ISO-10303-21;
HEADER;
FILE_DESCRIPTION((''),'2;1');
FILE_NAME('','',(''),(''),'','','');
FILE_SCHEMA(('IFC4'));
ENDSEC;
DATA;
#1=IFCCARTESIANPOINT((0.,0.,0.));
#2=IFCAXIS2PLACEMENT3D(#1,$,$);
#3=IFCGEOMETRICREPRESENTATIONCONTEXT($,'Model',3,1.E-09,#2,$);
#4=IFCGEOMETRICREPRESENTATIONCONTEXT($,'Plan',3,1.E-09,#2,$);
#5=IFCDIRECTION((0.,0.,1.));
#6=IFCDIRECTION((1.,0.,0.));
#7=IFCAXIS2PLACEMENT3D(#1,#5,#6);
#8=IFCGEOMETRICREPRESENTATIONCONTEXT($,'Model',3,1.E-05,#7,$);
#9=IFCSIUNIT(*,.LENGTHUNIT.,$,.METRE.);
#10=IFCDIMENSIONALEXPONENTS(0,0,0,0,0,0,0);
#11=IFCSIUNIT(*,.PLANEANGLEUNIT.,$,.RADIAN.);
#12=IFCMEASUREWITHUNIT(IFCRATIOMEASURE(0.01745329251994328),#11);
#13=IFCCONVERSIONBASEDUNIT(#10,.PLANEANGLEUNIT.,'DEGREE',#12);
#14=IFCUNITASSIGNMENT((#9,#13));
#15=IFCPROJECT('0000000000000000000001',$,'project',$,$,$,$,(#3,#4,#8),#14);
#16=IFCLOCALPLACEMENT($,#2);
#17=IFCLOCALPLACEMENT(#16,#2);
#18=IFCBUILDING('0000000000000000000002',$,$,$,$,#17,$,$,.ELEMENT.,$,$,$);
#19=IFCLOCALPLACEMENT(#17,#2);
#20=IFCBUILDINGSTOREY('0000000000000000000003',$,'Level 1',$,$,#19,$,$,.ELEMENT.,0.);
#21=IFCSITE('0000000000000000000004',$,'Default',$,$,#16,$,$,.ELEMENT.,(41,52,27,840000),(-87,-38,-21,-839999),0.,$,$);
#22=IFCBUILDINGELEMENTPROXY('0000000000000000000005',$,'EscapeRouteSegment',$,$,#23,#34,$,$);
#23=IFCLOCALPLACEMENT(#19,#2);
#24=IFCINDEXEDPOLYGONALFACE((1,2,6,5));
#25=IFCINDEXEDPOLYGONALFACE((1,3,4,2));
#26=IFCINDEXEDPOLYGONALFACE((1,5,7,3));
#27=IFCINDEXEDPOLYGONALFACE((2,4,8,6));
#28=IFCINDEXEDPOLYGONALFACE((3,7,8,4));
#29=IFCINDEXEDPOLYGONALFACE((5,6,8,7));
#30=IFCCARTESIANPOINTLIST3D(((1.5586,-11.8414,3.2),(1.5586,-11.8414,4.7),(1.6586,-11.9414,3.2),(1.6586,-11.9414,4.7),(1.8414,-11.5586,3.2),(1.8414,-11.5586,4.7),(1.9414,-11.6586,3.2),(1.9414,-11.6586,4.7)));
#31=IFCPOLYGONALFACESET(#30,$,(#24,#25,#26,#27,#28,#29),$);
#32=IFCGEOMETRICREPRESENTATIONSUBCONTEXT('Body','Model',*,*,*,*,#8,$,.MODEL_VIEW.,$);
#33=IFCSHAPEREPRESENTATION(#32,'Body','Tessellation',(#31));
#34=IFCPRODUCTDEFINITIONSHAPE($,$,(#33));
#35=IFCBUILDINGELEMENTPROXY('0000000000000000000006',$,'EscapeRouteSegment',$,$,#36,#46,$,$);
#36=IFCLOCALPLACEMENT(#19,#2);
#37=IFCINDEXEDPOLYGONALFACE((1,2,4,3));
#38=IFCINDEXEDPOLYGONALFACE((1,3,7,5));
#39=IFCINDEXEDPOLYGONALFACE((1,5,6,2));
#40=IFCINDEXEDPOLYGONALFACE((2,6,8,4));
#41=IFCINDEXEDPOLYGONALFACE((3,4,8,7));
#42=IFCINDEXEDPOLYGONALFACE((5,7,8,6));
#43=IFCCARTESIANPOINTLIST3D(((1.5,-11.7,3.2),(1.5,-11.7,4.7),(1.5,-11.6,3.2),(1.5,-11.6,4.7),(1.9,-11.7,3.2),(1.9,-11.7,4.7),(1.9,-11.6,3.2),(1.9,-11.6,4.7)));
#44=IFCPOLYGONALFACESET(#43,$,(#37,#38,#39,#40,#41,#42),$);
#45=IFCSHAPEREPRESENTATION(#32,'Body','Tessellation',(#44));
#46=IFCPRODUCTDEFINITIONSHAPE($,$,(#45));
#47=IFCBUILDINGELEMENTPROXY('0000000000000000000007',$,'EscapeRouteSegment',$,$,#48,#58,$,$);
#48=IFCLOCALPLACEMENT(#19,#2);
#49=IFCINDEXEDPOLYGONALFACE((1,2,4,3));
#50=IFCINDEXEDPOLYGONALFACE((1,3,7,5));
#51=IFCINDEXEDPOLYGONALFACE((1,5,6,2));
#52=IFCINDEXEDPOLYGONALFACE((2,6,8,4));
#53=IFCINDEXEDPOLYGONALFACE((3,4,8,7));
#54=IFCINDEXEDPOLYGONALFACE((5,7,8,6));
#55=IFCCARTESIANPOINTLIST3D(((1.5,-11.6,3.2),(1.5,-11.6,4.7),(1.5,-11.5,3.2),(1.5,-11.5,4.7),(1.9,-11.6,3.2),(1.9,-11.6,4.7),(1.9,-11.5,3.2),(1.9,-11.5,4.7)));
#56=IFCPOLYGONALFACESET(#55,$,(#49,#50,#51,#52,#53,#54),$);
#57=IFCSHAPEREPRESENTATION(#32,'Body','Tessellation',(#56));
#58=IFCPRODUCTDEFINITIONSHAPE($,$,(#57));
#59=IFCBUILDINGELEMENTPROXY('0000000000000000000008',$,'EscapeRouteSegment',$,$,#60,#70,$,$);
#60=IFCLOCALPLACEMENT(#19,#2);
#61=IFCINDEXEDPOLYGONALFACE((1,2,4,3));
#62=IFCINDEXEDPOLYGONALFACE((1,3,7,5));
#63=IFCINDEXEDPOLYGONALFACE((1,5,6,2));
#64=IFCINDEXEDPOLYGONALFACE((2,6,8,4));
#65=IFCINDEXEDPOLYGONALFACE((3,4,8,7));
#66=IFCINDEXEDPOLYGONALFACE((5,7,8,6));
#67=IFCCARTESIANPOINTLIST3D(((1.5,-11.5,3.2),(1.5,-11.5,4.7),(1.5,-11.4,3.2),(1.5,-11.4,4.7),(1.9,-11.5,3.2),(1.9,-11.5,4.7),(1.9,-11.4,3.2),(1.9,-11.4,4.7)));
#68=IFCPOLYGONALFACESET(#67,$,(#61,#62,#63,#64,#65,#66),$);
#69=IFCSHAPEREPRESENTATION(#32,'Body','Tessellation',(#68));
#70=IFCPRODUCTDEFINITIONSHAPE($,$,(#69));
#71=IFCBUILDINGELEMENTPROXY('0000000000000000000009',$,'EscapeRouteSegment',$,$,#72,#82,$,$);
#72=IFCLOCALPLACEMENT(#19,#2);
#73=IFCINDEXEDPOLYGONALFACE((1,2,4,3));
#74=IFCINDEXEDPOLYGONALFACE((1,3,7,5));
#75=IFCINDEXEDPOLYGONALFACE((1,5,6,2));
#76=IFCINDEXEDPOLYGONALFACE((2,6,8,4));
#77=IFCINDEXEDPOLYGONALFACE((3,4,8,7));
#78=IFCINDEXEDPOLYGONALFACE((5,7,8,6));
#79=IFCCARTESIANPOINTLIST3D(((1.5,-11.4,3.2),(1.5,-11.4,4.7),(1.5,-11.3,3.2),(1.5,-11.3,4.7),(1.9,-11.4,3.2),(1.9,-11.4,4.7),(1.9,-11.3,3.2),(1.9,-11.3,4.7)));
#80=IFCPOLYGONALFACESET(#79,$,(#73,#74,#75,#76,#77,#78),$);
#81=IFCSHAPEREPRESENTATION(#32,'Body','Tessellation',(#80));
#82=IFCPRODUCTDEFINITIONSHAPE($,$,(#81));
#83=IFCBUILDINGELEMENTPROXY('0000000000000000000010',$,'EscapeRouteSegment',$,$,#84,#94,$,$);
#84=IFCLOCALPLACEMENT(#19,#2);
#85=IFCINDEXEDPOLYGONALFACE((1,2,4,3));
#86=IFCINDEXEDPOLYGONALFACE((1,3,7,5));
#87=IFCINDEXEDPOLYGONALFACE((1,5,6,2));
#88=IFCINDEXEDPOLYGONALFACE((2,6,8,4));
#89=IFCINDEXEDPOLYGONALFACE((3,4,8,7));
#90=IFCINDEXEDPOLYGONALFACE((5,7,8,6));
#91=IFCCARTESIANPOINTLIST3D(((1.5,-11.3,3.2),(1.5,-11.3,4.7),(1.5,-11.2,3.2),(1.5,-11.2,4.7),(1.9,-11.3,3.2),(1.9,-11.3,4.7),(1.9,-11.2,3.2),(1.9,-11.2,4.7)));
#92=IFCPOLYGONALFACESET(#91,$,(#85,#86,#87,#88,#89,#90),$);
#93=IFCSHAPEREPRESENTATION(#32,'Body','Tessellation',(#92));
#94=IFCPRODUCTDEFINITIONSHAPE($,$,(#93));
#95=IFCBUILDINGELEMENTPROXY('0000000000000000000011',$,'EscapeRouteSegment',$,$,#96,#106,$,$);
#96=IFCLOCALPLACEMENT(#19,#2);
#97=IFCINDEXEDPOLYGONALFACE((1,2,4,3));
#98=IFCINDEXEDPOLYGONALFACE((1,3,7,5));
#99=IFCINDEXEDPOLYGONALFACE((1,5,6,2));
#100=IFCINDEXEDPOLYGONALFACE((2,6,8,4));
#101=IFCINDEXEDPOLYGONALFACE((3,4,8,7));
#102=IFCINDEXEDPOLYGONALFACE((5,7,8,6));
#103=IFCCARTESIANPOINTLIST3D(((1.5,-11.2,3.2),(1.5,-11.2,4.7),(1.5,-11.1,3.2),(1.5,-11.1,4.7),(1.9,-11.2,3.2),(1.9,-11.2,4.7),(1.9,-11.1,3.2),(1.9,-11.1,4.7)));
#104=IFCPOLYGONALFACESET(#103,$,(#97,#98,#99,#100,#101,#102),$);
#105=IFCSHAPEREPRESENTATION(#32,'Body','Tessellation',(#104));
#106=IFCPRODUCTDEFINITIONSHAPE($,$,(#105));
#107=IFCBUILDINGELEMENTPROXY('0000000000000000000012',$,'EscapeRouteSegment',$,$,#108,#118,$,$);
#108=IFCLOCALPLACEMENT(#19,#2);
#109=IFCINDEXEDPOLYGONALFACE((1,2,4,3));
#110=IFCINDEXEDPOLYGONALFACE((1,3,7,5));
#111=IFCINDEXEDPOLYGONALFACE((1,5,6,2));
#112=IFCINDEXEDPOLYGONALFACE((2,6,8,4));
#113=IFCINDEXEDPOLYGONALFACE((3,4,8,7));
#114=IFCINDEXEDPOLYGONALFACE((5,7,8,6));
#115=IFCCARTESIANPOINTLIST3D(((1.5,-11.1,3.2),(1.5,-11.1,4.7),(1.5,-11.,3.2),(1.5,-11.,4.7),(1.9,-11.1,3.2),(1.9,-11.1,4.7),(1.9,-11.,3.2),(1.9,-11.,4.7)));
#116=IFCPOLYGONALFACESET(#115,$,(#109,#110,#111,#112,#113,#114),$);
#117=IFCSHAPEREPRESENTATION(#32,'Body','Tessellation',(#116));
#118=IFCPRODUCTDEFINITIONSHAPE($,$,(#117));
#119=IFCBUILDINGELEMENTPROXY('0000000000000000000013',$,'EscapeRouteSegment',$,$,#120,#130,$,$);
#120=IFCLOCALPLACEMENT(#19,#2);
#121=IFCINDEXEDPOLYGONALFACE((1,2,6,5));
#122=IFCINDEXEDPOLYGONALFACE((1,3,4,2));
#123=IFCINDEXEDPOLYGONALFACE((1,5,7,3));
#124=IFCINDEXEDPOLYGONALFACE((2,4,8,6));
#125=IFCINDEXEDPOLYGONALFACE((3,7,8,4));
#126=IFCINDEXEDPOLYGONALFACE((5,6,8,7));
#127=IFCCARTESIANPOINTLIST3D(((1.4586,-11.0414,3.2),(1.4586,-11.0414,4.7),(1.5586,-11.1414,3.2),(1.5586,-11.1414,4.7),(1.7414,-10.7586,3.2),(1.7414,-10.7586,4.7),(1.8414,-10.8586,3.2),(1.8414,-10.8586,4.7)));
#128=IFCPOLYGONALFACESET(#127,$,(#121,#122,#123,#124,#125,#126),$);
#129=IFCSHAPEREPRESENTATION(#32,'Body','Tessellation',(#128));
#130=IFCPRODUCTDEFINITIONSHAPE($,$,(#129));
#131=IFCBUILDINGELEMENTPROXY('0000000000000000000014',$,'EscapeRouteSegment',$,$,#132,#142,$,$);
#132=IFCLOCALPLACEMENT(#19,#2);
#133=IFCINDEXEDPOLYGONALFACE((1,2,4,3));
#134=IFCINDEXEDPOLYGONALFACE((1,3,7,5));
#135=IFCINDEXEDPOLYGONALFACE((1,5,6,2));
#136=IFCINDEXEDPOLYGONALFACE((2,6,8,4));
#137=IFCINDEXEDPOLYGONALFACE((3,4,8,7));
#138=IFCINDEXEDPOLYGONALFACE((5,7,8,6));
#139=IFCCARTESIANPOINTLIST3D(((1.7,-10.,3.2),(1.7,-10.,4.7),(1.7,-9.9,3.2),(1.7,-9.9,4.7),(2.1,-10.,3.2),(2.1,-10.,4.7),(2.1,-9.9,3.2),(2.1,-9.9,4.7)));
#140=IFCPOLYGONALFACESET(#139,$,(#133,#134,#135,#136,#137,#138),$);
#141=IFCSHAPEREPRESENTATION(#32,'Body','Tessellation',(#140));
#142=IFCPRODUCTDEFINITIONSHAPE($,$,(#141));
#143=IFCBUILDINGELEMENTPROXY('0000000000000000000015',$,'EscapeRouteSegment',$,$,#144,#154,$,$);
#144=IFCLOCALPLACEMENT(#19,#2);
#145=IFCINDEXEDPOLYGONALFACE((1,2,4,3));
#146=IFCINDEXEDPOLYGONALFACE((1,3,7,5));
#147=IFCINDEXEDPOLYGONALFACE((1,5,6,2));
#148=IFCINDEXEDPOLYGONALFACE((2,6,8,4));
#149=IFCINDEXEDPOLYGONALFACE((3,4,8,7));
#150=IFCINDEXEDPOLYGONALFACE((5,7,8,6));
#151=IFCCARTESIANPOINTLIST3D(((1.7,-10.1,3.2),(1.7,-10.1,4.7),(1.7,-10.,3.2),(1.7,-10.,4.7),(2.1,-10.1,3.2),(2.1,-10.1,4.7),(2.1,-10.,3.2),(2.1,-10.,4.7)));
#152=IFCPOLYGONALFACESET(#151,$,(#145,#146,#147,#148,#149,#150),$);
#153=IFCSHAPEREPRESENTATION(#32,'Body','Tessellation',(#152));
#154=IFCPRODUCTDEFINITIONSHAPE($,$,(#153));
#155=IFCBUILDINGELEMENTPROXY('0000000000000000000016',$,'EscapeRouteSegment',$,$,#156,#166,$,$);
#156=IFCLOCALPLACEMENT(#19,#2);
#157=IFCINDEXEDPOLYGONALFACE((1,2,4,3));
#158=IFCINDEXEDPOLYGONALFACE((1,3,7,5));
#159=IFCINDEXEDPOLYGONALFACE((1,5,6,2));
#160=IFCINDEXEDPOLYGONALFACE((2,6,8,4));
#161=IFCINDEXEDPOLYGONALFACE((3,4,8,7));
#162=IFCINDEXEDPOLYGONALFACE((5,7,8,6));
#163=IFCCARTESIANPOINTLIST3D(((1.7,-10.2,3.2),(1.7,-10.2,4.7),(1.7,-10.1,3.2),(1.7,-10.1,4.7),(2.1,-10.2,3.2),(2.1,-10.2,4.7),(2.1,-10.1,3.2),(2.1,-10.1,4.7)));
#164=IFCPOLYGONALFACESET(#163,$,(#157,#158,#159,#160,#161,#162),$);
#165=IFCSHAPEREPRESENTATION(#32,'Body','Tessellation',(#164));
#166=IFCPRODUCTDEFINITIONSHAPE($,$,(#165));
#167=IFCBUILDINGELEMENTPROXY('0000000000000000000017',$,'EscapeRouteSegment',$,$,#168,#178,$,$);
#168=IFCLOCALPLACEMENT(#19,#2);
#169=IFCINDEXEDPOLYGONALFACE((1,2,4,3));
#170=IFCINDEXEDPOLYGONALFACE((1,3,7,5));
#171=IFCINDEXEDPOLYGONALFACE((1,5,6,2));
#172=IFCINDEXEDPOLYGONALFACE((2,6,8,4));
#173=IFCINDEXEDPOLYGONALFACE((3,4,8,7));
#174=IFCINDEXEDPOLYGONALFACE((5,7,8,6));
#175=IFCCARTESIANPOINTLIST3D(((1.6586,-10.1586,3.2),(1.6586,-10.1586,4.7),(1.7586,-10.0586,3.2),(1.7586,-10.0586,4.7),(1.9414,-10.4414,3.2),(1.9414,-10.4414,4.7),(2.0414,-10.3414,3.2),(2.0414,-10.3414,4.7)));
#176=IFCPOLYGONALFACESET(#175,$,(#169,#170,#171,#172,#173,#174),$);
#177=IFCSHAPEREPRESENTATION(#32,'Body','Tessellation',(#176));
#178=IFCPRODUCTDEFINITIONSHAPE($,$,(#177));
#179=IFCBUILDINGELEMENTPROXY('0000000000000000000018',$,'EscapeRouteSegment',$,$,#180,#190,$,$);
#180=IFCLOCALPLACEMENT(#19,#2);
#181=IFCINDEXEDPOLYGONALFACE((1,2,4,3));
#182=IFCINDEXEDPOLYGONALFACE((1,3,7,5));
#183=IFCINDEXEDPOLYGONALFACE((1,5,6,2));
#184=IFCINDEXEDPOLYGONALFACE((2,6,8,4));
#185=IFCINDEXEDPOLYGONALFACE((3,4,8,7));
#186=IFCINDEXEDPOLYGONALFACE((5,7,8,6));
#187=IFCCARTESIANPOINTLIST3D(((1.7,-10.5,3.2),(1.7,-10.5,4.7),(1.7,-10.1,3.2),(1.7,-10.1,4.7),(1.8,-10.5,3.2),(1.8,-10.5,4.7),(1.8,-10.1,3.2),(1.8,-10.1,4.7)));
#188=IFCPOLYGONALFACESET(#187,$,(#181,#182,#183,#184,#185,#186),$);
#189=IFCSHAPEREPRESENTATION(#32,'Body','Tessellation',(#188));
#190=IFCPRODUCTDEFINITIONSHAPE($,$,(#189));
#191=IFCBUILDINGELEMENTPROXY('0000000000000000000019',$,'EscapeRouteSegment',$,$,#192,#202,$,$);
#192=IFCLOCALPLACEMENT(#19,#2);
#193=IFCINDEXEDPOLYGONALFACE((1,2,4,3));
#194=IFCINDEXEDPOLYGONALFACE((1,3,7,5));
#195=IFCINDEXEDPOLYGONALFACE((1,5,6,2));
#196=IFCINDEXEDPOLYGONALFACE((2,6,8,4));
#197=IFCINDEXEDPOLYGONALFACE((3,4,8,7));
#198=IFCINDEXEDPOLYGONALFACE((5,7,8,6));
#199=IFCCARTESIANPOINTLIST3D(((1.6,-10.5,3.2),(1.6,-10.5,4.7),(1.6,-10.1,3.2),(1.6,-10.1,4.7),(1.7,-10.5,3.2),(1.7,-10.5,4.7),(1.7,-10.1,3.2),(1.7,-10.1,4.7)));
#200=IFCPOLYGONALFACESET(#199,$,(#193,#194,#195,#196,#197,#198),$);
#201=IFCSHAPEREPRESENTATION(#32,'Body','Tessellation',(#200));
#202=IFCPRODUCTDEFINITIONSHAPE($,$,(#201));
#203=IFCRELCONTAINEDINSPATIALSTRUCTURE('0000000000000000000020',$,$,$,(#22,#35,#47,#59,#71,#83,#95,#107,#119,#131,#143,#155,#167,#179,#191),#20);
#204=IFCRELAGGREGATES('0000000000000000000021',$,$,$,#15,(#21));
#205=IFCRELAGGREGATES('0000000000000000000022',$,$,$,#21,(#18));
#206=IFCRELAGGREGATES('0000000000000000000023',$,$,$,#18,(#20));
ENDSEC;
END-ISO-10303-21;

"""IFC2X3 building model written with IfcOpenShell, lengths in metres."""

from ifc_helpers import new_model, entity, si_unit, converted_unit, frame, origin, origin_with_axes, place, context, subcontext, project, spatial, polyline, outline, extrude, element, save


model = new_model("IFC2X3")

# Units and contexts
model_context_1 = context("Model", 3, precision=1e-09, world=origin())
plan_context = context("Plan", 3, precision=1e-09, world=origin())
model_context_2 = context("Model", 3, precision=1e-05, world=origin_with_axes())
body_context = subcontext(model_context_2, "Body", "Model", "MODEL_VIEW")
ifc_project = project(units=[si_unit("LENGTHUNIT", "METRE"), converted_unit("PLANEANGLEUNIT", "DEGREE", entity("IfcRatioMeasure", 0.01745329251994328), si_unit("PLANEANGLEUNIT", "RADIAN"), dimensions=[0, 0, 0, 0, 0, 0, 0])], contexts=[model_context_1, plan_context, model_context_2])

# Site, building, storey
site_placement = place(None, origin())
site = spatial("IfcSite", under=ifc_project, at=site_placement, Name="Default", CompositionType="ELEMENT", RefLatitude=(41, 52, 27, 840000), RefLongitude=(-87, -38, -21, -839999), RefElevation=0.0)
building_placement = place(site_placement, origin())
building = spatial("IfcBuilding", under=site, at=building_placement, CompositionType="ELEMENT")
storey_placement = place(building_placement, origin())
storey = spatial("IfcBuildingStorey", under=building, at=storey_placement, Name="Level 1", CompositionType="ELEMENT", Elevation=0.0)

# Building element proxies
proxy_1_placement = place(storey_placement, frame((1.8, -11.8, 3.2), z_axis=(0.0, 0.0, 1.0), x_axis=(-0.707105, 0.707108, 0.0)))
element("IfcBuildingElementProxy", 1, at=proxy_1_placement, inside=storey, Name="EscapeRouteSegment", context=body_context, shape_type="SweptSolid", body=[
    extrude(outline(polyline([(0.0, -0.2), (0.0, 0.2), (0.1414, 0.2), (0.1414, -0.2), (0.0, -0.2)])), origin_with_axes(), (0.0, 0.0, 1.0), 1.5),
])
proxy_2_placement = place(storey_placement, frame((1.7, -11.7, 3.2), z_axis=(0.0, 0.0, 1.0), x_axis=(0.0, 1.0, 0.0)))
element("IfcBuildingElementProxy", 2, at=proxy_2_placement, inside=storey, Name="EscapeRouteSegment", context=body_context, shape_type="SweptSolid", body=[
    extrude(outline(polyline([(0.0, -0.2), (0.0, 0.2), (0.1, 0.2), (0.1, -0.2), (0.0, -0.2)])), origin_with_axes(), (0.0, 0.0, 1.0), 1.5),
])
for number, where, z_axis, x_axis, name in (
    (3, (1.7, -11.6, 3.2), (0.0, 0.0, 1.0), (0.0, 1.0, 0.0), "EscapeRouteSegment"),
    (4, (1.7, -11.5, 3.2), (0.0, 0.0, 1.0), (0.0, 1.0, 0.0), "EscapeRouteSegment"),
):
    element("IfcBuildingElementProxy", number, at=place(storey_placement, frame(where, z_axis=z_axis, x_axis=x_axis)), inside=storey, Name=name, context=body_context, shape_type="SweptSolid", body=[
        extrude(outline(polyline([(0.0, -0.2), (0.0, 0.2), (0.1, 0.2), (0.1, -0.2), (0.0, -0.2)])), origin_with_axes(), (0.0, 0.0, 1.0), 1.5),
    ])
proxy_3_placement = place(storey_placement, frame((1.7, -11.4, 3.2), z_axis=(0.0, 0.0, 1.0), x_axis=(0.0, 1.0, 0.0)))
element("IfcBuildingElementProxy", 5, at=proxy_3_placement, inside=storey, Name="EscapeRouteSegment", context=body_context, shape_type="SweptSolid", body=[
    extrude(outline(polyline([(0.0, -0.2), (0.0, 0.2), (0.1, 0.2), (0.1, -0.2), (0.0, -0.2)])), origin_with_axes(), (0.0, 0.0, 1.0), 1.5),
])
proxy_4_placement = place(storey_placement, frame((1.7, -11.3, 3.2), z_axis=(0.0, 0.0, 1.0), x_axis=(0.0, 1.0, 0.0)))
element("IfcBuildingElementProxy", 6, at=proxy_4_placement, inside=storey, Name="EscapeRouteSegment", context=body_context, shape_type="SweptSolid", body=[
    extrude(outline(polyline([(0.0, -0.2), (0.0, 0.2), (0.1, 0.2), (0.1, -0.2), (0.0, -0.2)])), origin_with_axes(), (0.0, 0.0, 1.0), 1.5),
])
proxy_5_placement = place(storey_placement, frame((1.7, -11.2, 3.2), z_axis=(0.0, 0.0, 1.0), x_axis=(0.0, 1.0, 0.0)))
element("IfcBuildingElementProxy", 7, at=proxy_5_placement, inside=storey, Name="EscapeRouteSegment", context=body_context, shape_type="SweptSolid", body=[
    extrude(outline(polyline([(0.0, -0.2), (0.0, 0.2), (0.1, 0.2), (0.1, -0.2), (0.0, -0.2)])), origin_with_axes(), (0.0, 0.0, 1.0), 1.5),
])
proxy_6_placement = place(storey_placement, frame((1.7, -11.1, 3.2), z_axis=(0.0, 0.0, 1.0), x_axis=(0.0, 1.0, 0.0)))
element("IfcBuildingElementProxy", 8, at=proxy_6_placement, inside=storey, Name="EscapeRouteSegment", context=body_context, shape_type="SweptSolid", body=[
    extrude(outline(polyline([(0.0, -0.2), (0.0, 0.2), (0.1, 0.2), (0.1, -0.2), (0.0, -0.2)])), origin_with_axes(), (0.0, 0.0, 1.0), 1.5),
])
proxy_7_placement = place(storey_placement, frame((1.7, -11.0, 3.2), z_axis=(0.0, 0.0, 1.0), x_axis=(-0.707105, 0.707108, 0.0)))
element("IfcBuildingElementProxy", 9, at=proxy_7_placement, inside=storey, Name="EscapeRouteSegment", context=body_context, shape_type="SweptSolid", body=[
    extrude(outline(polyline([(0.0, -0.2), (0.0, 0.2), (0.1414, 0.2), (0.1414, -0.2), (0.0, -0.2)])), origin_with_axes(), (0.0, 0.0, 1.0), 1.5),
])
for number, where, z_axis, x_axis, name in (
    (10, (1.9, -9.9, 3.2), (0.0, 0.0, 1.0), (0.0, -1.0, 0.0), "EscapeRouteSegment"),
    (11, (1.9, -10.0, 3.2), (0.0, 0.0, 1.0), (0.0, -1.0, 0.0), "EscapeRouteSegment"),
):
    element("IfcBuildingElementProxy", number, at=place(storey_placement, frame(where, z_axis=z_axis, x_axis=x_axis)), inside=storey, Name=name, context=body_context, shape_type="SweptSolid", body=[
        extrude(outline(polyline([(0.0, -0.2), (0.0, 0.2), (0.1, 0.2), (0.1, -0.2), (0.0, -0.2)])), origin_with_axes(), (0.0, 0.0, 1.0), 1.5),
    ])
proxy_8_placement = place(storey_placement, frame((1.9, -10.1, 3.2), z_axis=(0.0, 0.0, 1.0), x_axis=(0.0, -1.0, 0.0)))
element("IfcBuildingElementProxy", 12, at=proxy_8_placement, inside=storey, Name="EscapeRouteSegment", context=body_context, shape_type="SweptSolid", body=[
    extrude(outline(polyline([(0.0, -0.2), (0.0, 0.2), (0.1, 0.2), (0.1, -0.2), (0.0, -0.2)])), origin_with_axes(), (0.0, 0.0, 1.0), 1.5),
])
proxy_9_placement = place(storey_placement, frame((1.9, -10.2, 3.2), z_axis=(0.0, 0.0, 1.0), x_axis=(-0.707105, -0.707108, 0.0)))
element("IfcBuildingElementProxy", 13, at=proxy_9_placement, inside=storey, Name="EscapeRouteSegment", context=body_context, shape_type="SweptSolid", body=[
    extrude(outline(polyline([(0.0, -0.2), (0.0, 0.2), (0.1414, 0.2), (0.1414, -0.2), (0.0, -0.2)])), origin_with_axes(), (0.0, 0.0, 1.0), 1.5),
])
proxy_10_placement = place(storey_placement, frame((1.8, -10.3, 3.2), z_axis=(0.0, 0.0, 1.0), x_axis=(-1.0, 0.0, 0.0)))
element("IfcBuildingElementProxy", 14, at=proxy_10_placement, inside=storey, Name="EscapeRouteSegment", context=body_context, shape_type="SweptSolid", body=[
    extrude(outline(polyline([(0.0, -0.2), (0.0, 0.2), (0.1, 0.2), (0.1, -0.2), (0.0, -0.2)])), origin_with_axes(), (0.0, 0.0, 1.0), 1.5),
])
proxy_11_placement = place(storey_placement, frame((1.7, -10.3, 3.2), z_axis=(0.0, 0.0, 1.0), x_axis=(-1.0, 0.0, 0.0)))
element("IfcBuildingElementProxy", 15, at=proxy_11_placement, inside=storey, Name="EscapeRouteSegment", context=body_context, shape_type="SweptSolid", body=[
    extrude(outline(polyline([(0.0, -0.2), (0.0, 0.2), (0.1, 0.2), (0.1, -0.2), (0.0, -0.2)])), origin_with_axes(), (0.0, 0.0, 1.0), 1.5),
])

save(model, "model.ifc")
